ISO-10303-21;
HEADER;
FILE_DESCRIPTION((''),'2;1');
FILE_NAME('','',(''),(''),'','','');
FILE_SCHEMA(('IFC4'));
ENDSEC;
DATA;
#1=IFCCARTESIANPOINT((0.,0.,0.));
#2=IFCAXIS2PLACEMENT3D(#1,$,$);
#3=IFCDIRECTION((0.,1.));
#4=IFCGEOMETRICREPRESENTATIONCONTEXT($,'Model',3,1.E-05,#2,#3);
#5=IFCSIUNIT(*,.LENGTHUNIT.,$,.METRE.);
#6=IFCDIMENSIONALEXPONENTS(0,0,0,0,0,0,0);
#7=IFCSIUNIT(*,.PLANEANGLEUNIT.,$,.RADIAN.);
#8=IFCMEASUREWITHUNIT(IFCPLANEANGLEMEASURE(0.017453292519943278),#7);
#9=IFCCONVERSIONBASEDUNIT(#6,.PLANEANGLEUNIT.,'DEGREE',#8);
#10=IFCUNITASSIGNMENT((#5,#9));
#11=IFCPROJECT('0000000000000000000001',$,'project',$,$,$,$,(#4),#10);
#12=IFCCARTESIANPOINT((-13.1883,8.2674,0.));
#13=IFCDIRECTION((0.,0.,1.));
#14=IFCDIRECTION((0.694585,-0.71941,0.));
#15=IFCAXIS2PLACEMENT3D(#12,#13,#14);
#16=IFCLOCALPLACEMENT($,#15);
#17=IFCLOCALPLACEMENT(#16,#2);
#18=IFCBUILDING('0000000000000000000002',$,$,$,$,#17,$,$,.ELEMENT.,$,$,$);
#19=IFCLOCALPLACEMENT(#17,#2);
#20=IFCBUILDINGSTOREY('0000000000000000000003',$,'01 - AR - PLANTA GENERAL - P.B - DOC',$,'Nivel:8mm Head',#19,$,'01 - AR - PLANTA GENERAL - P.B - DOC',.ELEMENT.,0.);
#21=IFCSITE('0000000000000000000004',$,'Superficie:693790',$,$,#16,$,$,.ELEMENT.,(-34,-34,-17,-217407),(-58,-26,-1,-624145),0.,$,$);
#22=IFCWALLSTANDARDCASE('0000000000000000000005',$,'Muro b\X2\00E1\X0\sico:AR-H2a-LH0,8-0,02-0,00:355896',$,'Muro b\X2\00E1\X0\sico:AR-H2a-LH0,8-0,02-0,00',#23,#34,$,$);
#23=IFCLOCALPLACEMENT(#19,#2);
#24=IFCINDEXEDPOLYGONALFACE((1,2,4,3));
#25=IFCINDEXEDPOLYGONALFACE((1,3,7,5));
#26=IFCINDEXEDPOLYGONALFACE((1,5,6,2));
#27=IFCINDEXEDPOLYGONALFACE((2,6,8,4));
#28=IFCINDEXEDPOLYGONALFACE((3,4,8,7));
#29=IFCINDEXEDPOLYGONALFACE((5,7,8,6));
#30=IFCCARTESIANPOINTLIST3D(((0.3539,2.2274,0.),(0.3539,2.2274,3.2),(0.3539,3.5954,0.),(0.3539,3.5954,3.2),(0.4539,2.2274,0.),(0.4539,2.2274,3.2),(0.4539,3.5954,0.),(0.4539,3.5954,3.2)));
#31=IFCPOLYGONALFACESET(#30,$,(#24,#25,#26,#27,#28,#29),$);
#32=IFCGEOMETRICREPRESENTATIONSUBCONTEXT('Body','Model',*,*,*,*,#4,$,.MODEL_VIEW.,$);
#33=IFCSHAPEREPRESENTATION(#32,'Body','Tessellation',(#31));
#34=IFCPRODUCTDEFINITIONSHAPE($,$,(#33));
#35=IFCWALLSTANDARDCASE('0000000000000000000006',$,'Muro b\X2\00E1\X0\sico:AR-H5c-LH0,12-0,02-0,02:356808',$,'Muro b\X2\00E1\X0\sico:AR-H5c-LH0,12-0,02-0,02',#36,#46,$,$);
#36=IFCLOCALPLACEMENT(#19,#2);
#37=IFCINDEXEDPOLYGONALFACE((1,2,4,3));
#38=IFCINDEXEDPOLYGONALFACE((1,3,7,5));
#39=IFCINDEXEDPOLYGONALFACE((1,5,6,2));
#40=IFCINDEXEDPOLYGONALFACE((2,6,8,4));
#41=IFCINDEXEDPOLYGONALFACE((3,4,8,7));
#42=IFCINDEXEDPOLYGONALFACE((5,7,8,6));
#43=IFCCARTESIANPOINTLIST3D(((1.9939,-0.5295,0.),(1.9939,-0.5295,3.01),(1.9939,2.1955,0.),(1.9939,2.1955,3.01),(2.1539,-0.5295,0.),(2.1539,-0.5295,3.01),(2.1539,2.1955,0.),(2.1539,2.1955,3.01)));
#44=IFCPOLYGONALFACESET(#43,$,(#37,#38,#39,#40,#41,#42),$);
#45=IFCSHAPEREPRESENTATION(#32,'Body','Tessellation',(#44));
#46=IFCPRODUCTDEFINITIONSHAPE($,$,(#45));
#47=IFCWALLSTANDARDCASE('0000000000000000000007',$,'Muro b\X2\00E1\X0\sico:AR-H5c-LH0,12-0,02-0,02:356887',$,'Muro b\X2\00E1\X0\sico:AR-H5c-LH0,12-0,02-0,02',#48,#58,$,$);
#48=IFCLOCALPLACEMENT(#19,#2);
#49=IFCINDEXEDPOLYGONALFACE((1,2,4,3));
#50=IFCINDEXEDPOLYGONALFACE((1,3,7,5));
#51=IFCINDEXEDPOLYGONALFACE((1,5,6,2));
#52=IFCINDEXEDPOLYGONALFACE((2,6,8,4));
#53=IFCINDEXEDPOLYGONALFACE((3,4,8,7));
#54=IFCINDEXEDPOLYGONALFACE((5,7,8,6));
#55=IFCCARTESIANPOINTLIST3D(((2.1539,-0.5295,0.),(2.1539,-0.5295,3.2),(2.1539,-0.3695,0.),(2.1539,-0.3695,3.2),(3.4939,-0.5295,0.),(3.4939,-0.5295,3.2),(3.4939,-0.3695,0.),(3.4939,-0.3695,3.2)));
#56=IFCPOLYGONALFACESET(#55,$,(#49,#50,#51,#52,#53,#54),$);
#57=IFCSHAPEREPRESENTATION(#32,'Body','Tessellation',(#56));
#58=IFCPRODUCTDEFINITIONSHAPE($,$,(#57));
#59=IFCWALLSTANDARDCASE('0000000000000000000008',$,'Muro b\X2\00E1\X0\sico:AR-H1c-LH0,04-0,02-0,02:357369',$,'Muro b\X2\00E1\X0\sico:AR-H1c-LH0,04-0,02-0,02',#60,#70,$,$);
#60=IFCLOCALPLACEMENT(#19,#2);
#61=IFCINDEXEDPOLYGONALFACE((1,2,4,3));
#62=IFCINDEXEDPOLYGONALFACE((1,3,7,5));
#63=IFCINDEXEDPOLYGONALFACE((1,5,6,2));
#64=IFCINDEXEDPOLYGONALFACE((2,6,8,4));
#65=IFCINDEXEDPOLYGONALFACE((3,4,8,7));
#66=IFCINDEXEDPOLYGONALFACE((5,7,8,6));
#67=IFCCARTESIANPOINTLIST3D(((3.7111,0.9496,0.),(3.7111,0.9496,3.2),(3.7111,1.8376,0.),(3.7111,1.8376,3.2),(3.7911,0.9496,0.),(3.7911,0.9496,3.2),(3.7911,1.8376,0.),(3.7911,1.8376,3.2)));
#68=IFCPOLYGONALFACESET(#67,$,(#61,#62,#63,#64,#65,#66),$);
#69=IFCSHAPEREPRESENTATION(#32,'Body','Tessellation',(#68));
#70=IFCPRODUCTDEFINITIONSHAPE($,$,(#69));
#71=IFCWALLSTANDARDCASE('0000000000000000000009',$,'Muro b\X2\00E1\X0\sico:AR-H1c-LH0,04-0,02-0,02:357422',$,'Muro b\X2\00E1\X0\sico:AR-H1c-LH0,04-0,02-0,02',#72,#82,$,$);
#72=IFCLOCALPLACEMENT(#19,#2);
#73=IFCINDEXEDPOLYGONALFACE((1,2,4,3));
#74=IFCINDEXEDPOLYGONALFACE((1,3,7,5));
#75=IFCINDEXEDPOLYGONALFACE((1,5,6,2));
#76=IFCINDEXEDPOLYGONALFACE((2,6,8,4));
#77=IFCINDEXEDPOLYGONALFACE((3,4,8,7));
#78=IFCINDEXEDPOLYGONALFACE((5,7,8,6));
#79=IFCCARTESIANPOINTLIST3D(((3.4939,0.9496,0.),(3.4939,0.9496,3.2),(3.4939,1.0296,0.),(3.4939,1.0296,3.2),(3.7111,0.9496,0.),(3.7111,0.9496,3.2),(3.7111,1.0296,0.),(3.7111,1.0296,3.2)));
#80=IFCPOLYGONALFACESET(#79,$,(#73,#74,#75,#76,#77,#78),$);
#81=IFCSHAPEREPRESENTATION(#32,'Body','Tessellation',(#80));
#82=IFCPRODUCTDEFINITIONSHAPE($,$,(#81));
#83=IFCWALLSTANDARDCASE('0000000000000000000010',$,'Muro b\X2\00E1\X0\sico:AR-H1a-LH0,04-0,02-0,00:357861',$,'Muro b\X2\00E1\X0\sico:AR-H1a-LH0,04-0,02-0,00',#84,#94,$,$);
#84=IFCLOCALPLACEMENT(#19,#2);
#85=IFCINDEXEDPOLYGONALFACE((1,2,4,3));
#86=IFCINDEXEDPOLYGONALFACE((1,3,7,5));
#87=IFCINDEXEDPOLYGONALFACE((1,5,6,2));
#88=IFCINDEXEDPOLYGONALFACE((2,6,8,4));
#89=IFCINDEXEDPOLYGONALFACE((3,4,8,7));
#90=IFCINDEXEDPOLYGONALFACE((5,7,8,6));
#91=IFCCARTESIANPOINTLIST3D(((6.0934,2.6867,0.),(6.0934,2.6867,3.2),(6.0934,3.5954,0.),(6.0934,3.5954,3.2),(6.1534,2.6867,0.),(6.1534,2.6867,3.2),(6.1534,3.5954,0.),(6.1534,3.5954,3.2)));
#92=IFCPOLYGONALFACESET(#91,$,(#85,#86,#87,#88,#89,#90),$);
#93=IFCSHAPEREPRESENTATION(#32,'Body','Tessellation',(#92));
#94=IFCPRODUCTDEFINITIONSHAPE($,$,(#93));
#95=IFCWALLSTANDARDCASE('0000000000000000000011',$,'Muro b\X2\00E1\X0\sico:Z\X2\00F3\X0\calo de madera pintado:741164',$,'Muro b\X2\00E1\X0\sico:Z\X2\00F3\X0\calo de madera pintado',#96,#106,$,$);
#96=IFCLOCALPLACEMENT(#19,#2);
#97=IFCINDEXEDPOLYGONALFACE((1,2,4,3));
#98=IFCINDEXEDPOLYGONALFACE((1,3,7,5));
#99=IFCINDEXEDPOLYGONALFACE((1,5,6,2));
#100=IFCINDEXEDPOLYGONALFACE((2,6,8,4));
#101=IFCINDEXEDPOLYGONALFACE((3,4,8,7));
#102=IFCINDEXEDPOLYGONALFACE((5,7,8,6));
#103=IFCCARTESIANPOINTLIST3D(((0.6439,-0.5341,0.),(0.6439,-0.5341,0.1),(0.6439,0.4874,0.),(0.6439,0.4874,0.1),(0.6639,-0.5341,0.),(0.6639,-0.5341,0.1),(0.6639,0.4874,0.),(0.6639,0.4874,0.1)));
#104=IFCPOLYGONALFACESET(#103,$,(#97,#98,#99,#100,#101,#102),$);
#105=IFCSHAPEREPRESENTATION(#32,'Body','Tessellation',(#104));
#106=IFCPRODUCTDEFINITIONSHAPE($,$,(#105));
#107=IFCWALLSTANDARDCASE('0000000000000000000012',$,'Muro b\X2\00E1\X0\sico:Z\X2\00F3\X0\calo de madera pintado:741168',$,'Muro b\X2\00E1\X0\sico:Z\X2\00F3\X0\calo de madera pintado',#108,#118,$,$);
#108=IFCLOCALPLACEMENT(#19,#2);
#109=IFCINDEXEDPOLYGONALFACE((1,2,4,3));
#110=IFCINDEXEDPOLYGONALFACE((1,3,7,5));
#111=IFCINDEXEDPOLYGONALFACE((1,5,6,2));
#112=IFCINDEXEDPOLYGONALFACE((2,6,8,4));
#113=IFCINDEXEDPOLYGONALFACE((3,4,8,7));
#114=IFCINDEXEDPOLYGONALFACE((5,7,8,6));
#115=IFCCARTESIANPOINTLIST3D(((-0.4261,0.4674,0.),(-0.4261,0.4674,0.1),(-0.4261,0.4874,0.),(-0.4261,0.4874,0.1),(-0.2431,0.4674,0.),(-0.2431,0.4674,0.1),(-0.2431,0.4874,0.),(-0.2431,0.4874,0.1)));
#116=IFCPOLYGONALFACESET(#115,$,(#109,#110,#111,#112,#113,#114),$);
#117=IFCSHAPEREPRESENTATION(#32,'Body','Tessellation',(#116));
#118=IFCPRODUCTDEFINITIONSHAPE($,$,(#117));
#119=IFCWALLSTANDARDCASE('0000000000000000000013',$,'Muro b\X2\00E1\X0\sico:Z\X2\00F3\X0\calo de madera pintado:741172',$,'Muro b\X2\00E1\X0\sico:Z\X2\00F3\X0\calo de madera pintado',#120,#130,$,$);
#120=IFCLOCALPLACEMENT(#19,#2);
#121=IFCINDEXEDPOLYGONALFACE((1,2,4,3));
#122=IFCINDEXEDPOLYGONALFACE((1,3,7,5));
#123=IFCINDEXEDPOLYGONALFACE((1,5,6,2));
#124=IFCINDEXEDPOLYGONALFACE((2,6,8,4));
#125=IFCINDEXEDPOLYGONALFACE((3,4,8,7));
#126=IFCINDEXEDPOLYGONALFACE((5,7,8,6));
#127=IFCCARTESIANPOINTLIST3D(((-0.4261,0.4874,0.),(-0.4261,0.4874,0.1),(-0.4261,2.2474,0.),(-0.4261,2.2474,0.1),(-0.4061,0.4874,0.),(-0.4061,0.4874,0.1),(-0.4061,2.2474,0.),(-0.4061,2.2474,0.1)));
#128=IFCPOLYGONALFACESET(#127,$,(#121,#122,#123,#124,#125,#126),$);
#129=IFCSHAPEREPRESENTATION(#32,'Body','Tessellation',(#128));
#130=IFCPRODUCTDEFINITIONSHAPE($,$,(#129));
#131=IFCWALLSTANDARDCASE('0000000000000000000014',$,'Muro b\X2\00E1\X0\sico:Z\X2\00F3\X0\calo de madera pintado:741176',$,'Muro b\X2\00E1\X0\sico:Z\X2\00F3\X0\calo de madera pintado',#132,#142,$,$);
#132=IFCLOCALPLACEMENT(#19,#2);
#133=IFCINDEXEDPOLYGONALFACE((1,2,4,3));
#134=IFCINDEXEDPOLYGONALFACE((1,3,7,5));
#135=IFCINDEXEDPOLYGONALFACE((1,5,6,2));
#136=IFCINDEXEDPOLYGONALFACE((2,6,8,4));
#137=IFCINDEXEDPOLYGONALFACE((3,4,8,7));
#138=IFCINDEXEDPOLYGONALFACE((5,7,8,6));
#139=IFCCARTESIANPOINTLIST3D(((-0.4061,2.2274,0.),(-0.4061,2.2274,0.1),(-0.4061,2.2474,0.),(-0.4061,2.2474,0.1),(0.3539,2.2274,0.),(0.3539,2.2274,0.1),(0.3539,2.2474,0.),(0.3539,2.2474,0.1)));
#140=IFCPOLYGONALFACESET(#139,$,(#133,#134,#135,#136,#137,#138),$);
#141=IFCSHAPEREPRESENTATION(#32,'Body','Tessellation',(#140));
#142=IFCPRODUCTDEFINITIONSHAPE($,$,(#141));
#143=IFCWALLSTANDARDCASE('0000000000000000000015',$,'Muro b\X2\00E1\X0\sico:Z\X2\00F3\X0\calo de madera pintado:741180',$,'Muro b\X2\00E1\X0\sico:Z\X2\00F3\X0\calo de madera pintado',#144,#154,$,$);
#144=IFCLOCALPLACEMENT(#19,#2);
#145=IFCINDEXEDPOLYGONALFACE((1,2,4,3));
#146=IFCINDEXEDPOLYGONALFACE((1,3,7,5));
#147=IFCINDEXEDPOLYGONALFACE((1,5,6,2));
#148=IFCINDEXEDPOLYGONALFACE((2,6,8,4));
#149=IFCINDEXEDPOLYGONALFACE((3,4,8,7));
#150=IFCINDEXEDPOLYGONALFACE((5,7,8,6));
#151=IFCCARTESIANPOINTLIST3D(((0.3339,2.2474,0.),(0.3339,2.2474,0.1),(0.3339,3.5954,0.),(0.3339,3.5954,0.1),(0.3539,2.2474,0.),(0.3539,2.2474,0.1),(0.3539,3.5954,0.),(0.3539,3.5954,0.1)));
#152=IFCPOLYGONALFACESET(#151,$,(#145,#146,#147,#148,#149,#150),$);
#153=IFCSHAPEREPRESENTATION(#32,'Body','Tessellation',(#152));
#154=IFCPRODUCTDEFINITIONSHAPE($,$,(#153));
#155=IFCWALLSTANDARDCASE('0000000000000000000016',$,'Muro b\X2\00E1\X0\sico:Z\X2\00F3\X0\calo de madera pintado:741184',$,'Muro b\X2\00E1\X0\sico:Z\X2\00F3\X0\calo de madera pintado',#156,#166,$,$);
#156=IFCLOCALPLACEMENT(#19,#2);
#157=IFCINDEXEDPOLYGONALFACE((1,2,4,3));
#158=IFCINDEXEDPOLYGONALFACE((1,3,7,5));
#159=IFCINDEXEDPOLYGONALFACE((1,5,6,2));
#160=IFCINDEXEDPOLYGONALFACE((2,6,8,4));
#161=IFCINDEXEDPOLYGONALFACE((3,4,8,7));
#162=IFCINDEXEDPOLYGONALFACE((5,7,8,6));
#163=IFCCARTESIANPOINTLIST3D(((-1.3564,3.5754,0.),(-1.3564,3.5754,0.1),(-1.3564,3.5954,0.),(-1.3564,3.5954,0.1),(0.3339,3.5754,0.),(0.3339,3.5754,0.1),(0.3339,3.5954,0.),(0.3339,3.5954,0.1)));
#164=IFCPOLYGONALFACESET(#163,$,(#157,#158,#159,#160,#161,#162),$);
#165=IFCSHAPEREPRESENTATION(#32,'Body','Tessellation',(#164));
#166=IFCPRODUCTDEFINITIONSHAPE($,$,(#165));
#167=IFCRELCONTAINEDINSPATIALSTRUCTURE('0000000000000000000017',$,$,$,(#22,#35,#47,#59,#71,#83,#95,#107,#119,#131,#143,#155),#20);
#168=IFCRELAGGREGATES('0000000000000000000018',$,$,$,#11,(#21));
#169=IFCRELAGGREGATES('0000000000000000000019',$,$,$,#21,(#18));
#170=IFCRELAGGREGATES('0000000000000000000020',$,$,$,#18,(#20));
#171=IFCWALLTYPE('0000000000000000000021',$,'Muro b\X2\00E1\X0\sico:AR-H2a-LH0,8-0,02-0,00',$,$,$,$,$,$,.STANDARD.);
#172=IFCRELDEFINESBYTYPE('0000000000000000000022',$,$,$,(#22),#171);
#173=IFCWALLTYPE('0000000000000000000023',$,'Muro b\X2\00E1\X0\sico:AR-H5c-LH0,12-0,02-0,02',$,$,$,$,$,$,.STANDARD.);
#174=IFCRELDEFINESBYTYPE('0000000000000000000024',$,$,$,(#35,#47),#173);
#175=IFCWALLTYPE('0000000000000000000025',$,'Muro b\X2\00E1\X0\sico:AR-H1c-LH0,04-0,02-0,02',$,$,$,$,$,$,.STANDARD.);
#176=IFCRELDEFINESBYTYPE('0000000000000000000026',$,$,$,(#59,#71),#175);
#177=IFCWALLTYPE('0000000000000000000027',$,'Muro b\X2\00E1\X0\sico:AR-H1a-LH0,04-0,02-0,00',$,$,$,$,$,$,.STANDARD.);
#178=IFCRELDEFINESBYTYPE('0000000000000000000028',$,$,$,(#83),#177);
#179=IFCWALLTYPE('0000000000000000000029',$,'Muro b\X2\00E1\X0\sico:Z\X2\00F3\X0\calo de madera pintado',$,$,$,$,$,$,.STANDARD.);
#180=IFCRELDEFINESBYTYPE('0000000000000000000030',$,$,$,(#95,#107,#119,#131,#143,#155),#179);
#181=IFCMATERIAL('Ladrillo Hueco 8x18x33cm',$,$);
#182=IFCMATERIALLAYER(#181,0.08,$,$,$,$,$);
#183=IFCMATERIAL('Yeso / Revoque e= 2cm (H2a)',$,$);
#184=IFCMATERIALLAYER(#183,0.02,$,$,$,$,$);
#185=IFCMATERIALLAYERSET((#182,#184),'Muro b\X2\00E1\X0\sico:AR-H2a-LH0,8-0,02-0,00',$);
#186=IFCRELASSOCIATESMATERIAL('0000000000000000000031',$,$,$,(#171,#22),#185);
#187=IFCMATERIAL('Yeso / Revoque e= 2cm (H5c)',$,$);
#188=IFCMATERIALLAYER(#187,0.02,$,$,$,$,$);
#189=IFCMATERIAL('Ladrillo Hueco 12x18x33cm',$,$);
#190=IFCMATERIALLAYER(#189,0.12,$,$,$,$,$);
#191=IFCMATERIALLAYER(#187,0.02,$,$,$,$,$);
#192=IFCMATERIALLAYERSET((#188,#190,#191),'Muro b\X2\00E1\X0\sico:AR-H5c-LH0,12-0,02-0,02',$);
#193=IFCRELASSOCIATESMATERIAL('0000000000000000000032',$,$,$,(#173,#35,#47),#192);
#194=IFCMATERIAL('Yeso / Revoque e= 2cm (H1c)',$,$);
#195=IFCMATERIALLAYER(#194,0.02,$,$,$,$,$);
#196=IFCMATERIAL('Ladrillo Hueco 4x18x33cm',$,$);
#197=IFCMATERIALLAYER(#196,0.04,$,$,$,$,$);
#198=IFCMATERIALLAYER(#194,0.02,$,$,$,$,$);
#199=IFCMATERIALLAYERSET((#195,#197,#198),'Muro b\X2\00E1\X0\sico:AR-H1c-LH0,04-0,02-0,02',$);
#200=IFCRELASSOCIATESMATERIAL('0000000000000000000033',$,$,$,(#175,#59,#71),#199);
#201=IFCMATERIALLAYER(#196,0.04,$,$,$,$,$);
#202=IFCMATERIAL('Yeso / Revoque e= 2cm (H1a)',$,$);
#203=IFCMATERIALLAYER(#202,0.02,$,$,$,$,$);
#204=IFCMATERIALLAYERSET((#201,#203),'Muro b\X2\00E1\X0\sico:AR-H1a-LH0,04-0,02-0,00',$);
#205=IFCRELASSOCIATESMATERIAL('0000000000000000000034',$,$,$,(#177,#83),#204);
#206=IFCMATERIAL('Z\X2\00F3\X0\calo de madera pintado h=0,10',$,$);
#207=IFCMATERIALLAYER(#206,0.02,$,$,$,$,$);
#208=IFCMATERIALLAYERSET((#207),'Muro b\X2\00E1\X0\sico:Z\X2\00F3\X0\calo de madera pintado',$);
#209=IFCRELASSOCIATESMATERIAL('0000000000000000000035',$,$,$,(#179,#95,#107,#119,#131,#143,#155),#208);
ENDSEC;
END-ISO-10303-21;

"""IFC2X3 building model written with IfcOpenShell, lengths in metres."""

from ifc_helpers import new_model, entity, si_unit, converted_unit, direction, frame, frame_2d, origin, place, context, subcontext, project, spatial, rectangle, extrude, material, layer, layer_set, layer_usage, type_object, element, save


model = new_model("IFC2X3")

# Units and contexts
model_context = context("Model", 3, precision=1e-05, world=origin(), true_north=direction((0.0, 1.0)))
body_context = subcontext(model_context, "Body", "Model", "MODEL_VIEW")
ifc_project = project(units=[si_unit("LENGTHUNIT", "METRE"), converted_unit("PLANEANGLEUNIT", "DEGREE", entity("IfcPlaneAngleMeasure", 0.017453292519943278), si_unit("PLANEANGLEUNIT", "RADIAN"), dimensions=[0, 0, 0, 0, 0, 0, 0])], contexts=[model_context])

# Site, building, storey
site_placement = place(None, frame((-13.1883, 8.2674, 0.0), z_axis=(0.0, 0.0, 1.0), x_axis=(0.694585, -0.71941, 0.0)))
site = spatial("IfcSite", under=ifc_project, at=site_placement, Name="Superficie:693790", CompositionType="ELEMENT", RefLatitude=(-34, -34, -17, -217407), RefLongitude=(-58, -26, -1, -624145), RefElevation=0.0)
building_placement = place(site_placement, origin())
building = spatial("IfcBuilding", under=site, at=building_placement, CompositionType="ELEMENT")
storey_placement = place(building_placement, origin())
storey = spatial("IfcBuildingStorey", under=building, at=storey_placement, Name="01 - AR - PLANTA GENERAL - P.B - DOC", ObjectType="Nivel:8mm Head", LongName="01 - AR - PLANTA GENERAL - P.B - DOC", CompositionType="ELEMENT", Elevation=0.0)

# Shared definitions
ifc_material_1 = material(Name="Ladrillo Hueco 8x18x33cm")

# Walls
ifc_layer_1 = layer(ifc_material_1, 0.08)
ifc_material_2 = material(Name="Yeso / Revoque e= 2cm (H2a)")
ifc_layer_2 = layer(ifc_material_2, 0.02)
ifc_layer_set_1 = layer_set([ifc_layer_1, ifc_layer_2], Name="Muro básico:AR-H2a-LH0,8-0,02-0,00")
ifc_layer_usage_1 = layer_usage(ifc_layer_set_1, "AXIS2", "POSITIVE", -0.05)
wall_type_1 = type_object("IfcWallType", Name="Muro básico:AR-H2a-LH0,8-0,02-0,00", PredefinedType="STANDARD", material=ifc_layer_set_1)
wall_1_placement = place(storey_placement, frame((0.4039, 2.2274, 0.0), z_axis=(0.0, 0.0, 1.0), x_axis=(0.0, 1.0, 0.0)))
element("IfcWallStandardCase", 1, at=wall_1_placement, inside=storey, type_object=wall_type_1, material=ifc_layer_usage_1, Name="Muro básico:AR-H2a-LH0,8-0,02-0,00:355896", ObjectType="Muro básico:AR-H2a-LH0,8-0,02-0,00", context=body_context, shape_type="SweptSolid", body=[
    extrude(rectangle(XDim=1.368, YDim=0.1, at=frame_2d((0.684, 0.0), x_axis=(-1.0, 0.0))), origin(), (0.0, 0.0, 1.0), 3.2),
])
ifc_material_3 = material(Name="Yeso / Revoque e= 2cm (H5c)")
ifc_layer_3 = layer(ifc_material_3, 0.02)
ifc_material_4 = material(Name="Ladrillo Hueco 12x18x33cm")
ifc_layer_4 = layer(ifc_material_4, 0.12)
ifc_layer_5 = layer(ifc_material_3, 0.02)
ifc_layer_set_2 = layer_set([ifc_layer_3, ifc_layer_4, ifc_layer_5], Name="Muro básico:AR-H5c-LH0,12-0,02-0,02")
ifc_layer_usage_2 = layer_usage(ifc_layer_set_2, "AXIS2", "NEGATIVE", 0.08)
wall_type_2 = type_object("IfcWallType", Name="Muro básico:AR-H5c-LH0,12-0,02-0,02", PredefinedType="STANDARD", material=ifc_layer_set_2)
wall_2_placement = place(storey_placement, frame((2.0739, -0.5295, 0.0), z_axis=(0.0, 0.0, 1.0), x_axis=(0.0, 1.0, 0.0)))
element("IfcWallStandardCase", 2, at=wall_2_placement, inside=storey, type_object=wall_type_2, material=ifc_layer_usage_2, Name="Muro básico:AR-H5c-LH0,12-0,02-0,02:356808", ObjectType="Muro básico:AR-H5c-LH0,12-0,02-0,02", context=body_context, shape_type="SweptSolid", body=[
    extrude(rectangle(XDim=2.725, YDim=0.16, at=frame_2d((1.3625, 0.0), x_axis=(-1.0, 0.0))), origin(), (0.0, 0.0, 1.0), 3.01),
])
ifc_layer_usage_3 = layer_usage(ifc_layer_set_2, "AXIS2", "POSITIVE", -0.08)
wall_3_placement = place(storey_placement, frame((2.1539, -0.4495, 0.0)))
element("IfcWallStandardCase", 3, at=wall_3_placement, inside=storey, type_object=wall_type_2, material=ifc_layer_usage_3, Name="Muro básico:AR-H5c-LH0,12-0,02-0,02:356887", ObjectType="Muro básico:AR-H5c-LH0,12-0,02-0,02", context=body_context, shape_type="SweptSolid", body=[
    extrude(rectangle(XDim=1.34, YDim=0.16, at=frame_2d((0.67, 0.0), x_axis=(-1.0, 0.0))), origin(), (0.0, 0.0, 1.0), 3.2),
])
ifc_material_5 = material(Name="Yeso / Revoque e= 2cm (H1c)")
ifc_layer_6 = layer(ifc_material_5, 0.02)
ifc_material_6 = material(Name="Ladrillo Hueco 4x18x33cm")
ifc_layer_7 = layer(ifc_material_6, 0.04)
ifc_layer_8 = layer(ifc_material_5, 0.02)
ifc_layer_set_3 = layer_set([ifc_layer_6, ifc_layer_7, ifc_layer_8], Name="Muro básico:AR-H1c-LH0,04-0,02-0,02")
ifc_layer_usage_4 = layer_usage(ifc_layer_set_3, "AXIS2", "NEGATIVE", 0.04)
wall_type_3 = type_object("IfcWallType", Name="Muro básico:AR-H1c-LH0,04-0,02-0,02", PredefinedType="STANDARD", material=ifc_layer_set_3)
wall_4_placement = place(storey_placement, frame((3.7511, 1.8376, 0.0), z_axis=(0.0, 0.0, 1.0), x_axis=(0.0, -1.0, 0.0)))
element("IfcWallStandardCase", 4, at=wall_4_placement, inside=storey, type_object=wall_type_3, material=ifc_layer_usage_4, Name="Muro básico:AR-H1c-LH0,04-0,02-0,02:357369", ObjectType="Muro básico:AR-H1c-LH0,04-0,02-0,02", context=body_context, shape_type="SweptSolid", body=[
    extrude(rectangle(XDim=0.888, YDim=0.08, at=frame_2d((0.444, 0.0), x_axis=(-1.0, 0.0))), origin(), (0.0, 0.0, 1.0), 3.2),
])
ifc_layer_usage_5 = layer_usage(ifc_layer_set_3, "AXIS2", "NEGATIVE", 0.04)
wall_5_placement = place(storey_placement, frame((3.7111, 0.9896, 0.0), z_axis=(0.0, 0.0, 1.0), x_axis=(-1.0, 0.0, 0.0)))
element("IfcWallStandardCase", 5, at=wall_5_placement, inside=storey, type_object=wall_type_3, material=ifc_layer_usage_5, Name="Muro básico:AR-H1c-LH0,04-0,02-0,02:357422", ObjectType="Muro básico:AR-H1c-LH0,04-0,02-0,02", context=body_context, shape_type="SweptSolid", body=[
    extrude(rectangle(XDim=0.2171, YDim=0.08, at=frame_2d((0.1086, 0.0), x_axis=(-1.0, 0.0))), origin(), (0.0, 0.0, 1.0), 3.2),
])
ifc_layer_9 = layer(ifc_material_6, 0.04)
ifc_material_7 = material(Name="Yeso / Revoque e= 2cm (H1a)")
ifc_layer_10 = layer(ifc_material_7, 0.02)
ifc_layer_set_4 = layer_set([ifc_layer_9, ifc_layer_10], Name="Muro básico:AR-H1a-LH0,04-0,02-0,00")
ifc_layer_usage_6 = layer_usage(ifc_layer_set_4, "AXIS2", "POSITIVE", -0.03)
wall_type_4 = type_object("IfcWallType", Name="Muro básico:AR-H1a-LH0,04-0,02-0,00", PredefinedType="STANDARD", material=ifc_layer_set_4)
wall_6_placement = place(storey_placement, frame((6.1234, 3.5954, 0.0), z_axis=(0.0, 0.0, 1.0), x_axis=(0.0, -1.0, 0.0)))
element("IfcWallStandardCase", 6, at=wall_6_placement, inside=storey, type_object=wall_type_4, material=ifc_layer_usage_6, Name="Muro básico:AR-H1a-LH0,04-0,02-0,00:357861", ObjectType="Muro básico:AR-H1a-LH0,04-0,02-0,00", context=body_context, shape_type="SweptSolid", body=[
    extrude(rectangle(XDim=0.9087, YDim=0.06, at=frame_2d((0.4544, 0.0), x_axis=(-1.0, 0.0))), origin(), (0.0, 0.0, 1.0), 3.2),
])
ifc_material_8 = material(Name="Zócalo de madera pintado h=0,10")
ifc_layer_11 = layer(ifc_material_8, 0.02)
ifc_layer_set_5 = layer_set([ifc_layer_11], Name="Muro básico:Zócalo de madera pintado")
ifc_layer_usage_7 = layer_usage(ifc_layer_set_5, "AXIS2", "NEGATIVE", 0.01)
wall_type_5 = type_object("IfcWallType", Name="Muro básico:Zócalo de madera pintado", PredefinedType="STANDARD", material=ifc_layer_set_5)
wall_7_placement = place(storey_placement, frame((0.6539, 0.4874, 0.0), z_axis=(0.0, 0.0, 1.0), x_axis=(0.0, -1.0, 0.0)))
element("IfcWallStandardCase", 7, at=wall_7_placement, inside=storey, type_object=wall_type_5, material=ifc_layer_usage_7, Name="Muro básico:Zócalo de madera pintado:741164", ObjectType="Muro básico:Zócalo de madera pintado", context=body_context, shape_type="SweptSolid", body=[
    extrude(rectangle(XDim=1.0215, YDim=0.02, at=frame_2d((0.5107, 0.0), x_axis=(-1.0, 0.0))), origin(), (0.0, 0.0, 1.0), 0.1),
])
ifc_layer_usage_8 = layer_usage(ifc_layer_set_5, "AXIS2", "NEGATIVE", 0.01)
wall_8_placement = place(storey_placement, frame((-0.4261, 0.4774, 0.0)))
element("IfcWallStandardCase", 8, at=wall_8_placement, inside=storey, type_object=wall_type_5, material=ifc_layer_usage_8, Name="Muro básico:Zócalo de madera pintado:741168", ObjectType="Muro básico:Zócalo de madera pintado", context=body_context, shape_type="SweptSolid", body=[
    extrude(rectangle(XDim=0.183, YDim=0.02, at=frame_2d((0.0915, 0.0), x_axis=(-1.0, 0.0))), origin(), (0.0, 0.0, 1.0), 0.1),
])
ifc_layer_usage_9 = layer_usage(ifc_layer_set_5, "AXIS2", "NEGATIVE", 0.01)
wall_9_placement = place(storey_placement, frame((-0.4161, 2.2474, 0.0), z_axis=(0.0, 0.0, 1.0), x_axis=(0.0, -1.0, 0.0)))
element("IfcWallStandardCase", 9, at=wall_9_placement, inside=storey, type_object=wall_type_5, material=ifc_layer_usage_9, Name="Muro básico:Zócalo de madera pintado:741172", ObjectType="Muro básico:Zócalo de madera pintado", context=body_context, shape_type="SweptSolid", body=[
    extrude(rectangle(XDim=1.76, YDim=0.02, at=frame_2d((0.88, 0.0), x_axis=(-1.0, 0.0))), origin(), (0.0, 0.0, 1.0), 0.1),
])
ifc_layer_usage_10 = layer_usage(ifc_layer_set_5, "AXIS2", "NEGATIVE", 0.01)
wall_10_placement = place(storey_placement, frame((0.3539, 2.2374, 0.0), z_axis=(0.0, 0.0, 1.0), x_axis=(-1.0, 0.0, 0.0)))
element("IfcWallStandardCase", 10, at=wall_10_placement, inside=storey, type_object=wall_type_5, material=ifc_layer_usage_10, Name="Muro básico:Zócalo de madera pintado:741176", ObjectType="Muro básico:Zócalo de madera pintado", context=body_context, shape_type="SweptSolid", body=[
    extrude(rectangle(XDim=0.76, YDim=0.02, at=frame_2d((0.38, 0.0), x_axis=(-1.0, 0.0))), origin(), (0.0, 0.0, 1.0), 0.1),
])
ifc_layer_usage_11 = layer_usage(ifc_layer_set_5, "AXIS2", "NEGATIVE", 0.01)
wall_11_placement = place(storey_placement, frame((0.3439, 3.5954, 0.0), z_axis=(0.0, 0.0, 1.0), x_axis=(0.0, -1.0, 0.0)))
element("IfcWallStandardCase", 11, at=wall_11_placement, inside=storey, type_object=wall_type_5, material=ifc_layer_usage_11, Name="Muro básico:Zócalo de madera pintado:741180", ObjectType="Muro básico:Zócalo de madera pintado", context=body_context, shape_type="SweptSolid", body=[
    extrude(rectangle(XDim=1.348, YDim=0.02, at=frame_2d((0.674, 0.0), x_axis=(-1.0, 0.0))), origin(), (0.0, 0.0, 1.0), 0.1),
])
ifc_layer_usage_12 = layer_usage(ifc_layer_set_5, "AXIS2", "NEGATIVE", 0.01)
wall_12_placement = place(storey_placement, frame((-1.3564, 3.5854, 0.0)))
element("IfcWallStandardCase", 12, at=wall_12_placement, inside=storey, type_object=wall_type_5, material=ifc_layer_usage_12, Name="Muro básico:Zócalo de madera pintado:741184", ObjectType="Muro básico:Zócalo de madera pintado", context=body_context, shape_type="SweptSolid", body=[
    extrude(rectangle(XDim=1.6904, YDim=0.02, at=frame_2d((0.8452, 0.0), x_axis=(-1.0, 0.0))), origin(), (0.0, 0.0, 1.0), 0.1),
])

save(model, "model.ifc")
